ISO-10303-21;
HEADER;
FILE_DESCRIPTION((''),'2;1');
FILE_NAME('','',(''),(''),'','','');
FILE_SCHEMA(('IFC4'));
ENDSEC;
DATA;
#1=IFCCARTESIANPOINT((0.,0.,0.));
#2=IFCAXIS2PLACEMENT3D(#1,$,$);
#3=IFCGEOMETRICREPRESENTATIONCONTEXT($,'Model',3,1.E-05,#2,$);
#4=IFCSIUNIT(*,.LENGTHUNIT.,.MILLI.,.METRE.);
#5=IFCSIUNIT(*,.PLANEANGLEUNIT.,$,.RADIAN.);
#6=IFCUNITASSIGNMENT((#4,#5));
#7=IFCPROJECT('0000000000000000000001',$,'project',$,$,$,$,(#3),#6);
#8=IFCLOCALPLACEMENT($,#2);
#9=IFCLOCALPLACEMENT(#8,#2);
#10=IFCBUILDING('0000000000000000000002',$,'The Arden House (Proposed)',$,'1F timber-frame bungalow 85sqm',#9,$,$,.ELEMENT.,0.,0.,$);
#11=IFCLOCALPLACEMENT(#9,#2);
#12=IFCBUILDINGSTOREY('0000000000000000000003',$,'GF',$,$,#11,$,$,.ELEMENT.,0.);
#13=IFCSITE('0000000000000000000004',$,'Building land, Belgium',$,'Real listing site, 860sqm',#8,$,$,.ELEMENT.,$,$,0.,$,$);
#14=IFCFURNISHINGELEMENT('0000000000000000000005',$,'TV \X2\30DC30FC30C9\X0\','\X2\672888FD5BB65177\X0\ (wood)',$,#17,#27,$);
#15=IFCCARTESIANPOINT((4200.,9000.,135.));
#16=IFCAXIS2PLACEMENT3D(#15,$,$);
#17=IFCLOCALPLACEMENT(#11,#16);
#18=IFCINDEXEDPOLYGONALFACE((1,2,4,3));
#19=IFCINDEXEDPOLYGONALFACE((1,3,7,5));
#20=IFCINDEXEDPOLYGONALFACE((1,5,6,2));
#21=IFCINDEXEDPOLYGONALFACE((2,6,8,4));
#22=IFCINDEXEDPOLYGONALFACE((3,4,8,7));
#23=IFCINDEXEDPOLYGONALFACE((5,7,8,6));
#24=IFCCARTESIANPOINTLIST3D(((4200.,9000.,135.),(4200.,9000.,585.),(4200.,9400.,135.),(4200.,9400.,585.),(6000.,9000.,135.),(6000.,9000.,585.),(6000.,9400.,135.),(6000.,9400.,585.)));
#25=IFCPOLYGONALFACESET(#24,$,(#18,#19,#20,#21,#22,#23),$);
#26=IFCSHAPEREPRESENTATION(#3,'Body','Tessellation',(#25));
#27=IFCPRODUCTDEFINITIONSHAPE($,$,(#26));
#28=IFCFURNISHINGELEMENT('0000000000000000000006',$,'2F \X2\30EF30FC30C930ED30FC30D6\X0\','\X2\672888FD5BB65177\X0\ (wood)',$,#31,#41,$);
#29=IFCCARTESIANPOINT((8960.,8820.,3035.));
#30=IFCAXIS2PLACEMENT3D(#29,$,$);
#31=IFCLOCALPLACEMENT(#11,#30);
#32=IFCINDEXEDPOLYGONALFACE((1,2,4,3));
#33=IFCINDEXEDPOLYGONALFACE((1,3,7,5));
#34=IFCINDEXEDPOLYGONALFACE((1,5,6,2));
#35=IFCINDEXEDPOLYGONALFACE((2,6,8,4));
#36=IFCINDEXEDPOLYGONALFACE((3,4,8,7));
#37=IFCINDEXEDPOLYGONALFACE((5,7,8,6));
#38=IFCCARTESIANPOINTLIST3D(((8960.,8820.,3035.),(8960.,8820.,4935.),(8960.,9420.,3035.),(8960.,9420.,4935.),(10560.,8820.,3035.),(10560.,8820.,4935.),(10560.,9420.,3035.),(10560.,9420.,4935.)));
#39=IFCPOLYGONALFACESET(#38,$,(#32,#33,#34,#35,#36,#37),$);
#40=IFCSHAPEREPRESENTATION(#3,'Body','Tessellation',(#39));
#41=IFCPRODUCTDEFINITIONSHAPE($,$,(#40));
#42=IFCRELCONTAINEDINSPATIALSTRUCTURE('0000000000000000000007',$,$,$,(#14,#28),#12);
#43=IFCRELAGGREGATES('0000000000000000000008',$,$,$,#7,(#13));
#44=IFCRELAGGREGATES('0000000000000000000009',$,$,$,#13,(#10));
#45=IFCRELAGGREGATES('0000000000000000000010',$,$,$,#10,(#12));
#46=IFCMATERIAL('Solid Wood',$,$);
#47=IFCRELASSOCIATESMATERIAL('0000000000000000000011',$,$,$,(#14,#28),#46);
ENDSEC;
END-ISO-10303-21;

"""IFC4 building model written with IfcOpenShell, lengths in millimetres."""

from ifc_helpers import new_model, si_unit, frame, frame_2d, origin, place, context, project, spatial, rectangle, extrude, material, element, save


model = new_model("IFC4")

# Units and contexts
model_context = context("Model", 3, precision=1e-05, world=origin())
ifc_project = project(units=[si_unit("LENGTHUNIT", "METRE", prefix="MILLI"), si_unit("PLANEANGLEUNIT", "RADIAN")], contexts=[model_context])

# Site, building, storey
site_placement = place(None, origin())
site = spatial("IfcSite", under=ifc_project, at=site_placement, Name="Building land, Belgium", ObjectType="Real listing site, 860sqm", CompositionType="ELEMENT", RefElevation=0.0)
building_placement = place(site_placement, origin())
building = spatial("IfcBuilding", under=site, at=building_placement, Name="The Arden House (Proposed)", ObjectType="1F timber-frame bungalow 85sqm", CompositionType="ELEMENT", ElevationOfRefHeight=0.0, ElevationOfTerrain=0.0)
storey_placement = place(building_placement, origin())
storey = spatial("IfcBuildingStorey", under=building, at=storey_placement, Name="GF", CompositionType="ELEMENT", Elevation=0.0)

# Shared definitions
ifc_material_1 = material(Name="Solid Wood")

# Furnishing elements
furnishing_1_placement = place(storey_placement, frame((4200.0, 9000.0, 135.0)))
element("IfcFurnishingElement", 1, at=furnishing_1_placement, inside=storey, material=ifc_material_1, Name="TV ボード", Description="木製家具 (wood)", context=model_context, shape_type="SweptSolid", body=[
    extrude(rectangle(XDim=1800.0, YDim=400.0, at=frame_2d((900.0, 200.0))), frame((4200.0, 9000.0, 135.0)), (0.0, 0.0, 1.0), 450.0),
])
furnishing_2_placement = place(storey_placement, frame((8960.0, 8820.0, 3035.0)))
element("IfcFurnishingElement", 2, at=furnishing_2_placement, inside=storey, material=ifc_material_1, Name="2F ワードローブ", Description="木製家具 (wood)", context=model_context, shape_type="SweptSolid", body=[
    extrude(rectangle(XDim=1600.0, YDim=600.0, at=frame_2d((800.0, 300.0))), frame((8960.0, 8820.0, 3035.0)), (0.0, 0.0, 1.0), 1900.0),
])

save(model, "model.ifc")
